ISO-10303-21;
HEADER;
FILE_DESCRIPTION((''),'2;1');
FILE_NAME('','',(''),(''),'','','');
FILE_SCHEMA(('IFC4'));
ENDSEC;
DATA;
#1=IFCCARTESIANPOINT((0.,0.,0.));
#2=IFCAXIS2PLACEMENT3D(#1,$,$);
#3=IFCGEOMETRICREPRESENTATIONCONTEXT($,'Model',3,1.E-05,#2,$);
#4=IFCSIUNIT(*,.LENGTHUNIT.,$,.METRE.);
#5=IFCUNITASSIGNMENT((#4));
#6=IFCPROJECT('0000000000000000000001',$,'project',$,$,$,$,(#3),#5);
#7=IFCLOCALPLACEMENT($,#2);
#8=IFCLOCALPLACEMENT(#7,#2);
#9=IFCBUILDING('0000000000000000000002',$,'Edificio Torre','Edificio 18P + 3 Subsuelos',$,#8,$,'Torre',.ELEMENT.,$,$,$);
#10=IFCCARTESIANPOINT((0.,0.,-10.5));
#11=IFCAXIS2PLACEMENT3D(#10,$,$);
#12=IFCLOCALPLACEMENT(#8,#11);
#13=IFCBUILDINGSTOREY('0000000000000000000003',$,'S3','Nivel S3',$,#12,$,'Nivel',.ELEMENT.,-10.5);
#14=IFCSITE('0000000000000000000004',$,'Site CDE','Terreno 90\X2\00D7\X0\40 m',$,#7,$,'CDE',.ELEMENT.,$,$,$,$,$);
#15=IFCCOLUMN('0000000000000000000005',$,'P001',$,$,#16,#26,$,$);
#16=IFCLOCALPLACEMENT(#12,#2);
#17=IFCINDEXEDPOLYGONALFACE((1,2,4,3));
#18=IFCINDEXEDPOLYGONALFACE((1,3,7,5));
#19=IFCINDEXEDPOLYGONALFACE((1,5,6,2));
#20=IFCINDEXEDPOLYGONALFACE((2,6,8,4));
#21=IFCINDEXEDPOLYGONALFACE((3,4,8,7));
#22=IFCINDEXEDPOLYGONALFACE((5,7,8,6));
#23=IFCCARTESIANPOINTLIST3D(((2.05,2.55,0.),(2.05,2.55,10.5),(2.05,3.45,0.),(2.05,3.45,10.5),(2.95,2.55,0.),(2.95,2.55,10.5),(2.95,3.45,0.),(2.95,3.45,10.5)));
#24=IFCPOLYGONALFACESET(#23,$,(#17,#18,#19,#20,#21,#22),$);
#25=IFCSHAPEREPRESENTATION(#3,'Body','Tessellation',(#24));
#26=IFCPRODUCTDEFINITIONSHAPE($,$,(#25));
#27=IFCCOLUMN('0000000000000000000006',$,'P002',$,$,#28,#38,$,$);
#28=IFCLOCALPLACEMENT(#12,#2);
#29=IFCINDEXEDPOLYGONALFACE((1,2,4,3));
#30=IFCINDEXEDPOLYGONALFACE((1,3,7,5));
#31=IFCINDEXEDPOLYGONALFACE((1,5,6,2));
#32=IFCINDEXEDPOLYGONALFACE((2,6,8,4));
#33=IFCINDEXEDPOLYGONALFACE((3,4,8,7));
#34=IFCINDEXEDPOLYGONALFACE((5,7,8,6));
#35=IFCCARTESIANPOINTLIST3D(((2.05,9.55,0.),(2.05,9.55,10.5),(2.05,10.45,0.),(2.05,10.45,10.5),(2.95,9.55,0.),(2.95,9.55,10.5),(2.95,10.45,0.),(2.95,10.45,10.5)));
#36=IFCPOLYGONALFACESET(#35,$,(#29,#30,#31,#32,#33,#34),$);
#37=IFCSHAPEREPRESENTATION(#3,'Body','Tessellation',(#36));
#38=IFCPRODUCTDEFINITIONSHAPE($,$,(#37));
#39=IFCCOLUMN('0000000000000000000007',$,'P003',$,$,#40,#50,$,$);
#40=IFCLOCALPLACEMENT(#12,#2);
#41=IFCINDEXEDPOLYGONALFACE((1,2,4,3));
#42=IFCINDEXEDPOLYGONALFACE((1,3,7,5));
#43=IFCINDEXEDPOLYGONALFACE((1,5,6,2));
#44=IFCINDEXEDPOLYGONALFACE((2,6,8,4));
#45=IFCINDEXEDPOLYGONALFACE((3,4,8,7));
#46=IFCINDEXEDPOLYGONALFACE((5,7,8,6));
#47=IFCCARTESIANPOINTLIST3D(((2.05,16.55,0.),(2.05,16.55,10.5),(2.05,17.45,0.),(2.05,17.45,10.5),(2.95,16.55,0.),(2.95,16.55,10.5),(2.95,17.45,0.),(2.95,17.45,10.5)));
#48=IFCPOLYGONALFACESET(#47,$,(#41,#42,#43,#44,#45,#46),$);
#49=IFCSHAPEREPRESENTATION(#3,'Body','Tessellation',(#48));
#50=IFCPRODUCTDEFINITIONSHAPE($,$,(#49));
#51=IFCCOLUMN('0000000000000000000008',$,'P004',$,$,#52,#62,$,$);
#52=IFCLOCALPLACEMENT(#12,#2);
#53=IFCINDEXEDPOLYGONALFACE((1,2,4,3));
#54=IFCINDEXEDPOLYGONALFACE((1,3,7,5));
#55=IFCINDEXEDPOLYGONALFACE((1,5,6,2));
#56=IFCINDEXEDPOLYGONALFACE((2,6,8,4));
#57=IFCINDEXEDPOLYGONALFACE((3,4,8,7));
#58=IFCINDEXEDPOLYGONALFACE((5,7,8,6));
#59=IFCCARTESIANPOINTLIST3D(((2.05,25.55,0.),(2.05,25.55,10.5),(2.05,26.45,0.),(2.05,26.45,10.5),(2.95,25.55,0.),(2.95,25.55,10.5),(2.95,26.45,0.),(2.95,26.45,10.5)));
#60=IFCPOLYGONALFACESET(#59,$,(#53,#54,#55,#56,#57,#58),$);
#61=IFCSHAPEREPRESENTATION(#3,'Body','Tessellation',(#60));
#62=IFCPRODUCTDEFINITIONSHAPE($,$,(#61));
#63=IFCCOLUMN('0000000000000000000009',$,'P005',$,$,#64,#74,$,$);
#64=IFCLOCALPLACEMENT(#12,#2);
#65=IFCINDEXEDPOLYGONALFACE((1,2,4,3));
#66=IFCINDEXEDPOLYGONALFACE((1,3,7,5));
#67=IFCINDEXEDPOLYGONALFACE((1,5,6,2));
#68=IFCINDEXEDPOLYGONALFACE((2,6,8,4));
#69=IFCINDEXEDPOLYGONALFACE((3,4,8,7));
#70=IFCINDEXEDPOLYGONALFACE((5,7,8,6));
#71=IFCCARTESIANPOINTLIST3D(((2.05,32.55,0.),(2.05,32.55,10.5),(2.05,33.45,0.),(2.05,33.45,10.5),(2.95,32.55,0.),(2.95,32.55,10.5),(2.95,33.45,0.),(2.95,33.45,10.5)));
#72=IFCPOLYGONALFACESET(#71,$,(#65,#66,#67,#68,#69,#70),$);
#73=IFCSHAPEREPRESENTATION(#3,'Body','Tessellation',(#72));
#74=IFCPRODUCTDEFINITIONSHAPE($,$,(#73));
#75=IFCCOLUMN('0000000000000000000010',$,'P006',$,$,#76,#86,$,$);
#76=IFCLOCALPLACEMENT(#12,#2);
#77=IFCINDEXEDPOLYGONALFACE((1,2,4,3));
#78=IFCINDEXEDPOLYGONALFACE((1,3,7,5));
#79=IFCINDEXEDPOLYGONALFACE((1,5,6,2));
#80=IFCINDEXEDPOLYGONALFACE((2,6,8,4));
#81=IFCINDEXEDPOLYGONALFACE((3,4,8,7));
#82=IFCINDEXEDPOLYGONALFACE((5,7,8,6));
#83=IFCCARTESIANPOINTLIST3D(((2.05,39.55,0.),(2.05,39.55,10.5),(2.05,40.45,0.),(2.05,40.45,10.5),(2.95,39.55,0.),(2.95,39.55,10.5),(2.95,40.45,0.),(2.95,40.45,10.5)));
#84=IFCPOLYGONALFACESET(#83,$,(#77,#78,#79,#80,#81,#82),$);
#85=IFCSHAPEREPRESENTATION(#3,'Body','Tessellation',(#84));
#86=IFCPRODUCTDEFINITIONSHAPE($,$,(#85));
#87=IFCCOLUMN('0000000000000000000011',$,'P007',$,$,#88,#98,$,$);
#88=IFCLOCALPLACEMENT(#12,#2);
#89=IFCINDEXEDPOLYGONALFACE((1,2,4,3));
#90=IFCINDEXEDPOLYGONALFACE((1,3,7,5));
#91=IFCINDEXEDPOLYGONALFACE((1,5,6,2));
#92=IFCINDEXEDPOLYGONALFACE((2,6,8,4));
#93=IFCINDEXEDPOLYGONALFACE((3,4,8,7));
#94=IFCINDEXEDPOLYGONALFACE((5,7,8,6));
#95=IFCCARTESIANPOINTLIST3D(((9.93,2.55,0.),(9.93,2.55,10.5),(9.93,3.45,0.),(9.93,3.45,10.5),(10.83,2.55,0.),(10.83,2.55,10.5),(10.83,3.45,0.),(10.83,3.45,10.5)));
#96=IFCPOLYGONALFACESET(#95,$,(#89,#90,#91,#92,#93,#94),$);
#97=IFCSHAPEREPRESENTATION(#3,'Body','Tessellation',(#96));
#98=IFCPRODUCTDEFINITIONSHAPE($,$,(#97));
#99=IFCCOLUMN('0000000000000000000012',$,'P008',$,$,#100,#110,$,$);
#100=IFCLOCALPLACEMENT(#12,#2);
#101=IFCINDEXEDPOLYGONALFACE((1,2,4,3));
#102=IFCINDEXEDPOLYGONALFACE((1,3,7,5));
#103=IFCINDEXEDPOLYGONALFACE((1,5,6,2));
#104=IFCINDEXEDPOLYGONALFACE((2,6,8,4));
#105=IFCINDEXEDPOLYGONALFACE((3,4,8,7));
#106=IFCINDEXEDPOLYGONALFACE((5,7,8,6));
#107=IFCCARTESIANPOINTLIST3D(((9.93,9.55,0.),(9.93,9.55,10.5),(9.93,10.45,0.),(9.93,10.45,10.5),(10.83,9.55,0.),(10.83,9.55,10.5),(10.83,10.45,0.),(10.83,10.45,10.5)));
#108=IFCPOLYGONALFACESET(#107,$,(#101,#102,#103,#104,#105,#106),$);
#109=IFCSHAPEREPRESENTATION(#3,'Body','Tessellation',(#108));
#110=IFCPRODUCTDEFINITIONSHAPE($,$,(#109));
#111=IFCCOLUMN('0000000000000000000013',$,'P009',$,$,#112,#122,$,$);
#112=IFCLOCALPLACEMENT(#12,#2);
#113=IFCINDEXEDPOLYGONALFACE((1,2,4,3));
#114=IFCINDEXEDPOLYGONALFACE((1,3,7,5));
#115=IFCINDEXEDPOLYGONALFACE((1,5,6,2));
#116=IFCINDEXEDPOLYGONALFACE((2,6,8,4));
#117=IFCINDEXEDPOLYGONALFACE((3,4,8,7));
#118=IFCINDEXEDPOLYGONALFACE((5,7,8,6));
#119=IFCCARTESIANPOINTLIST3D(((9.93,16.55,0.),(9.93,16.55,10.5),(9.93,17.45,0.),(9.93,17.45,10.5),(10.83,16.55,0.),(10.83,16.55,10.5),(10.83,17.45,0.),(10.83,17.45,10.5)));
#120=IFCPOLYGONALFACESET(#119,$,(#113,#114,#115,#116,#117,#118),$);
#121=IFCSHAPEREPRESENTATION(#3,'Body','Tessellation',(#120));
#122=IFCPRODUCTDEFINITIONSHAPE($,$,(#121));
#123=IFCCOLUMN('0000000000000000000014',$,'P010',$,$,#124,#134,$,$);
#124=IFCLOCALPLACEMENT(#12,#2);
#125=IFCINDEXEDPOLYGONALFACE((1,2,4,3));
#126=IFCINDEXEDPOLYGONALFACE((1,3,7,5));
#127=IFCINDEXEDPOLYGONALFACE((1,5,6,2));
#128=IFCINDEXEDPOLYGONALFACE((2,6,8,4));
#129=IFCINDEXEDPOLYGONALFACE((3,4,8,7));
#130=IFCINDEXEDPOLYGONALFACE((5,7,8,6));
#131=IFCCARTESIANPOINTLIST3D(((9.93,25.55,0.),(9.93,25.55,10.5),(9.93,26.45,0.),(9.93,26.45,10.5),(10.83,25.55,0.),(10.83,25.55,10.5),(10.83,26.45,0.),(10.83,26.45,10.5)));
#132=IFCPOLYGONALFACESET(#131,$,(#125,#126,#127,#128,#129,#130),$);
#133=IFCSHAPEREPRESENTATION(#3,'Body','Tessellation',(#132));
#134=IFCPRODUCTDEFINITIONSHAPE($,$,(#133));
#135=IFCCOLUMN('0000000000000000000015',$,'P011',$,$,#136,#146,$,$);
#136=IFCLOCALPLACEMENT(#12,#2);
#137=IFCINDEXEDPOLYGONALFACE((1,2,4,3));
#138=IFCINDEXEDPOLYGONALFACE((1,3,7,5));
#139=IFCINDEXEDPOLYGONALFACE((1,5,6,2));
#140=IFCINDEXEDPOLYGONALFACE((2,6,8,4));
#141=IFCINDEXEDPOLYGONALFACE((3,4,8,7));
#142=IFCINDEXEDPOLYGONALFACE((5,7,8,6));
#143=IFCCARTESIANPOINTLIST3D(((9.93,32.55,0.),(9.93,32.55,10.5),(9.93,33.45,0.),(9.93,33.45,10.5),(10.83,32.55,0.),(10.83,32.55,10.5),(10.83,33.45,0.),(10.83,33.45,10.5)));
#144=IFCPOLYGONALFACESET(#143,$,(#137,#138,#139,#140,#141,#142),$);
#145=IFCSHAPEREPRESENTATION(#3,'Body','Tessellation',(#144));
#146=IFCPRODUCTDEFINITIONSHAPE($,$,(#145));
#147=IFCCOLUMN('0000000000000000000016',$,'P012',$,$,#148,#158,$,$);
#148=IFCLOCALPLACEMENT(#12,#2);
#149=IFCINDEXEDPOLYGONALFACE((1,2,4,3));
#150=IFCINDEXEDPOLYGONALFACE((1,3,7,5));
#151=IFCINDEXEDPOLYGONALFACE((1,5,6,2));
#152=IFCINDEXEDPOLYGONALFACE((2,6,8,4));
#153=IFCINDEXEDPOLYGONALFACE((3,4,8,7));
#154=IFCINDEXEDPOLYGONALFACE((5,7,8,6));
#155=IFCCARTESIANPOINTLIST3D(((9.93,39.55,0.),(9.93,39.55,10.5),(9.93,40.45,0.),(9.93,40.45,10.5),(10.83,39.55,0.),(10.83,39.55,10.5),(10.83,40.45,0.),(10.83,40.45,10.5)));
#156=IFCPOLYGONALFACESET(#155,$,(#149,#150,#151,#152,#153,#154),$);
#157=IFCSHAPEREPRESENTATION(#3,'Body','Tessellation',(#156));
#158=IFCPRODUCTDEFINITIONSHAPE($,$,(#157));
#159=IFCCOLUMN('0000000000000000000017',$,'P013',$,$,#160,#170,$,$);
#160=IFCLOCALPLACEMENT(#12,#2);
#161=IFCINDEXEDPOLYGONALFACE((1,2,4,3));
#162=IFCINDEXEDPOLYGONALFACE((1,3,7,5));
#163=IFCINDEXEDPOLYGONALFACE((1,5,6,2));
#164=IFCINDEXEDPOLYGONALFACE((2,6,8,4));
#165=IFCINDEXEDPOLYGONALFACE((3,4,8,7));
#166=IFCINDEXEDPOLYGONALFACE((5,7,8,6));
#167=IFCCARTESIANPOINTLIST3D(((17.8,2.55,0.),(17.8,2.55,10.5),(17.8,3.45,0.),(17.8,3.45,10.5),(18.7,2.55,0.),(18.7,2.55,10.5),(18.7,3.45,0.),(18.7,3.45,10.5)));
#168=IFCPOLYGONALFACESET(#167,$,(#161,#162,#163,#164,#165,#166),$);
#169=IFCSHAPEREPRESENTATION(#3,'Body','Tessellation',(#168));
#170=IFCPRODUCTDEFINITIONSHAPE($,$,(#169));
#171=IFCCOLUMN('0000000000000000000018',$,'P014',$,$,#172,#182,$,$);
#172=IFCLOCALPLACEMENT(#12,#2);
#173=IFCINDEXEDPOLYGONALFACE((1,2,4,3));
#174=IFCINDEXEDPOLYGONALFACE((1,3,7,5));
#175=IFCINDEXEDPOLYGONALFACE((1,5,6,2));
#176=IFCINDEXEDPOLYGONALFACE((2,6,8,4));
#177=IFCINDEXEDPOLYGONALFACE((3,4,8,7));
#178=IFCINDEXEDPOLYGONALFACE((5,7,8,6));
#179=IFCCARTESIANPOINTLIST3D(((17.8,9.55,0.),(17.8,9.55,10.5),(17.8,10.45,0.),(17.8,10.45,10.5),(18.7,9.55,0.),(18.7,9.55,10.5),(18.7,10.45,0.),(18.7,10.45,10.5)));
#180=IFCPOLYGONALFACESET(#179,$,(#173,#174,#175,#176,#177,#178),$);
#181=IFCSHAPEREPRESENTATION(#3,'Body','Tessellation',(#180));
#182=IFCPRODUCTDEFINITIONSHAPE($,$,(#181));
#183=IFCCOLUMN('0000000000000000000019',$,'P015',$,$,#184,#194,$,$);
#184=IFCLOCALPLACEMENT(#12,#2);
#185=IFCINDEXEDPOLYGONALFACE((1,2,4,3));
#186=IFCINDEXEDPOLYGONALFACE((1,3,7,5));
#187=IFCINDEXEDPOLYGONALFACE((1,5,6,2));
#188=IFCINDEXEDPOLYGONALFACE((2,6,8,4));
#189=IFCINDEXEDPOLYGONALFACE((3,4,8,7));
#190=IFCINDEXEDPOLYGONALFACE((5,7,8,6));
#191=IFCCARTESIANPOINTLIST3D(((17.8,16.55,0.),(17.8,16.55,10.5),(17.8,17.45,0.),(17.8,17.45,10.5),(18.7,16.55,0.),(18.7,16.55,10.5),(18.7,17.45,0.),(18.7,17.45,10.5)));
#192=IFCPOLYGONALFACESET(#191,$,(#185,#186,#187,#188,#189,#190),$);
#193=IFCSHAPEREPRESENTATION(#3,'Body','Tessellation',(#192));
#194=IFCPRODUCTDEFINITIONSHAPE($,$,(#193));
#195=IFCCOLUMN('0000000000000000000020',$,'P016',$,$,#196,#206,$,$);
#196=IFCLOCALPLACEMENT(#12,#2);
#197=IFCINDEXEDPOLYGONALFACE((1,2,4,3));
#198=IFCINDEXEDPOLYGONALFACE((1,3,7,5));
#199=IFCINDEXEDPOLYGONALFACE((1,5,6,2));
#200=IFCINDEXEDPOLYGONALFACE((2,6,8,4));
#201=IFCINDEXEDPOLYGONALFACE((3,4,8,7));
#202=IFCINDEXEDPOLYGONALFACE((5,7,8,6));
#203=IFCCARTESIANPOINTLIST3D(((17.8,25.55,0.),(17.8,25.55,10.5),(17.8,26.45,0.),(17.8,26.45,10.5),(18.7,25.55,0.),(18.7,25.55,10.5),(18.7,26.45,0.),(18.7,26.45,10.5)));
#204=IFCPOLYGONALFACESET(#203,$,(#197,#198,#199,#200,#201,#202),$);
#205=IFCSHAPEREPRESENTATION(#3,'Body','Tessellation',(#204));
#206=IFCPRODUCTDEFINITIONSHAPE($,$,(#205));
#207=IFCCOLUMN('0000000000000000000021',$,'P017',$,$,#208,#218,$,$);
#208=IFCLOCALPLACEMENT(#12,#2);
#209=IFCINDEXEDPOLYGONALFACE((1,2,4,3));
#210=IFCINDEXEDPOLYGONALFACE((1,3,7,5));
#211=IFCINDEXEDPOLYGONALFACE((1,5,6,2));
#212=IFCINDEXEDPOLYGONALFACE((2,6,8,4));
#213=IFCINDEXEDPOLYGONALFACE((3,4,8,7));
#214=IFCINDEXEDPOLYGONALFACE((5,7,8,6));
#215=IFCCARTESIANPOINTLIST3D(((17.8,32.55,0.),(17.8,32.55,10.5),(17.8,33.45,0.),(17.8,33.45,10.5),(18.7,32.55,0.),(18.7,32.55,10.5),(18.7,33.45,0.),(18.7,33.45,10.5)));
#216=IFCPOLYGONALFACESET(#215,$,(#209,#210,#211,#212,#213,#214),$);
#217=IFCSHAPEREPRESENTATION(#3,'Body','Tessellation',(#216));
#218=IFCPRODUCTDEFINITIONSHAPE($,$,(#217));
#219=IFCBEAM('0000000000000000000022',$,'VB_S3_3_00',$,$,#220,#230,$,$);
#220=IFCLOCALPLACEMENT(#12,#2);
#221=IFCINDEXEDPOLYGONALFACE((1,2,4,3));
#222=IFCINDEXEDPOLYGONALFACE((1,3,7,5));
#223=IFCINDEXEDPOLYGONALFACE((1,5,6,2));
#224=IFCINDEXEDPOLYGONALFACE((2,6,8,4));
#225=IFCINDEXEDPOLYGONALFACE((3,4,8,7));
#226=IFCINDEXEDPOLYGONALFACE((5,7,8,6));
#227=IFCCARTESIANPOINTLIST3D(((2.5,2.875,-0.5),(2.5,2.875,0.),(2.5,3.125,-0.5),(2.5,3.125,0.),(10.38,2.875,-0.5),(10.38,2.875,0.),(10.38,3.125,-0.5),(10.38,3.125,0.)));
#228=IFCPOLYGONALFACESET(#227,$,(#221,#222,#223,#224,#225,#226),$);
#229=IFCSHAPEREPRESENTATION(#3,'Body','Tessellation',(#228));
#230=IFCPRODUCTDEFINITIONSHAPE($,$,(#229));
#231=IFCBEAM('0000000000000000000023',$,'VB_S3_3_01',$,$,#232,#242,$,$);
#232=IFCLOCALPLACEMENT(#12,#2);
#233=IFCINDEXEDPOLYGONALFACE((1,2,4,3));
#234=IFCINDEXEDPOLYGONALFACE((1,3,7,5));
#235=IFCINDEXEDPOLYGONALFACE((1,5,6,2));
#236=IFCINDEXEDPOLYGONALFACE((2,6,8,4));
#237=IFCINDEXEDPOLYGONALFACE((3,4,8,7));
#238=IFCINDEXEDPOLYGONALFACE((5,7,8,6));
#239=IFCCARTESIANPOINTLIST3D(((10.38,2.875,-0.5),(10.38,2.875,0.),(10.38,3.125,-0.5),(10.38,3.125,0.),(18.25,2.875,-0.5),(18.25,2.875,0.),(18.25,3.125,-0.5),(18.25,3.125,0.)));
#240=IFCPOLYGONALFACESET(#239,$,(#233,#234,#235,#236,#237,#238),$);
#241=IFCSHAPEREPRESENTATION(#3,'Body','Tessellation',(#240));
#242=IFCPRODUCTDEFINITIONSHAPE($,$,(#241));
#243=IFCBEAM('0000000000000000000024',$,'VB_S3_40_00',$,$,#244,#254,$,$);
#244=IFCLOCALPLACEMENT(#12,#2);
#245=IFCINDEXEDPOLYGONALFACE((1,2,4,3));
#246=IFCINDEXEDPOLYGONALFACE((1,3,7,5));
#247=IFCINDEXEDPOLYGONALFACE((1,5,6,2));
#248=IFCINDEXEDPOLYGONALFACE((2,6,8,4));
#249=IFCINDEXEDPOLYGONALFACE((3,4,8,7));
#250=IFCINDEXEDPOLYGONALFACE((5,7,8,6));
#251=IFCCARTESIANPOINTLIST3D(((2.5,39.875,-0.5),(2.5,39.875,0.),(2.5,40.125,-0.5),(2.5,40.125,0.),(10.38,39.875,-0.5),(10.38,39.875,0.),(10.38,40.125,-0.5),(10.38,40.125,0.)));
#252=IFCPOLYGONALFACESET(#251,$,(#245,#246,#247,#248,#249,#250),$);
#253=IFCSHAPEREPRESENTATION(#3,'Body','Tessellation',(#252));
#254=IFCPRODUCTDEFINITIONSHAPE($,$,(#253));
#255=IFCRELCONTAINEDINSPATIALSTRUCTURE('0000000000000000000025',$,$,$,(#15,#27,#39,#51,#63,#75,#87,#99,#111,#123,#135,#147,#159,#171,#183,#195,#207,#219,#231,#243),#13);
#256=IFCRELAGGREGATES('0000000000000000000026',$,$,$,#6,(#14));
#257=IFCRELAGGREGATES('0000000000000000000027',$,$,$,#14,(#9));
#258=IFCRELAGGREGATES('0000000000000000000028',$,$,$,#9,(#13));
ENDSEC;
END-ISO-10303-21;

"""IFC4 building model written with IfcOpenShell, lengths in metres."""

from ifc_helpers import new_model, si_unit, frame, origin, origin_2d, place, context, project, spatial, rectangle, extrude, element, save


model = new_model("IFC4")

# Units and contexts
model_context = context("Model", 3, precision=1e-05, world=origin())
ifc_project = project(units=[si_unit("LENGTHUNIT", "METRE")], contexts=[model_context])

# Site, building, storey
site_placement = place(None, origin())
site = spatial("IfcSite", under=ifc_project, at=site_placement, Name="Site CDE", Description="Terreno 90×40 m", LongName="CDE", CompositionType="ELEMENT")
building_placement = place(site_placement, origin())
building = spatial("IfcBuilding", under=site, at=building_placement, Name="Edificio Torre", Description="Edificio 18P + 3 Subsuelos", LongName="Torre", CompositionType="ELEMENT")
storey_placement = place(building_placement, frame((0.0, 0.0, -10.5)))
storey = spatial("IfcBuildingStorey", under=building, at=storey_placement, Name="S3", Description="Nivel S3", LongName="Nivel", CompositionType="ELEMENT", Elevation=-10.5)

# Columns
for number, where, name in (
    (1, (2.5, 3.0, 0.0), "P001"),
    (2, (2.5, 10.0, 0.0), "P002"),
    (3, (2.5, 17.0, 0.0), "P003"),
    (4, (2.5, 26.0, 0.0), "P004"),
    (5, (2.5, 33.0, 0.0), "P005"),
    (6, (2.5, 40.0, 0.0), "P006"),
    (7, (10.38, 3.0, 0.0), "P007"),
    (8, (10.38, 10.0, 0.0), "P008"),
    (9, (10.38, 17.0, 0.0), "P009"),
    (10, (10.38, 26.0, 0.0), "P010"),
    (11, (10.38, 33.0, 0.0), "P011"),
    (12, (10.38, 40.0, 0.0), "P012"),
    (13, (18.25, 3.0, 0.0), "P013"),
    (14, (18.25, 10.0, 0.0), "P014"),
    (15, (18.25, 17.0, 0.0), "P015"),
    (16, (18.25, 26.0, 0.0), "P016"),
    (17, (18.25, 33.0, 0.0), "P017"),
):
    element("IfcColumn", number, at=place(storey_placement, frame(where)), inside=storey, Name=name, context=model_context, shape_type="SweptSolid", body=[
        extrude(rectangle(XDim=0.9, YDim=0.9, at=origin_2d()), origin(), (0.0, 0.0, 1.0), 10.5),
    ])

# Beams
beam_1_placement = place(storey_placement, frame((6.44, 3.0, -0.5)))
element("IfcBeam", 18, at=beam_1_placement, inside=storey, Name="VB_S3_3_00", context=model_context, shape_type="SweptSolid", body=[
    extrude(rectangle(XDim=7.88, YDim=0.25, at=origin_2d()), origin(), (0.0, 0.0, 1.0), 0.5),
])
beam_2_placement = place(storey_placement, frame((14.315, 3.0, -0.5)))
element("IfcBeam", 19, at=beam_2_placement, inside=storey, Name="VB_S3_3_01", context=model_context, shape_type="SweptSolid", body=[
    extrude(rectangle(XDim=7.87, YDim=0.25, at=origin_2d()), origin(), (0.0, 0.0, 1.0), 0.5),
])
beam_3_placement = place(storey_placement, frame((6.44, 40.0, -0.5)))
element("IfcBeam", 20, at=beam_3_placement, inside=storey, Name="VB_S3_40_00", context=model_context, shape_type="SweptSolid", body=[
    extrude(rectangle(XDim=7.88, YDim=0.25, at=origin_2d()), origin(), (0.0, 0.0, 1.0), 0.5),
])

save(model, "model.ifc")
